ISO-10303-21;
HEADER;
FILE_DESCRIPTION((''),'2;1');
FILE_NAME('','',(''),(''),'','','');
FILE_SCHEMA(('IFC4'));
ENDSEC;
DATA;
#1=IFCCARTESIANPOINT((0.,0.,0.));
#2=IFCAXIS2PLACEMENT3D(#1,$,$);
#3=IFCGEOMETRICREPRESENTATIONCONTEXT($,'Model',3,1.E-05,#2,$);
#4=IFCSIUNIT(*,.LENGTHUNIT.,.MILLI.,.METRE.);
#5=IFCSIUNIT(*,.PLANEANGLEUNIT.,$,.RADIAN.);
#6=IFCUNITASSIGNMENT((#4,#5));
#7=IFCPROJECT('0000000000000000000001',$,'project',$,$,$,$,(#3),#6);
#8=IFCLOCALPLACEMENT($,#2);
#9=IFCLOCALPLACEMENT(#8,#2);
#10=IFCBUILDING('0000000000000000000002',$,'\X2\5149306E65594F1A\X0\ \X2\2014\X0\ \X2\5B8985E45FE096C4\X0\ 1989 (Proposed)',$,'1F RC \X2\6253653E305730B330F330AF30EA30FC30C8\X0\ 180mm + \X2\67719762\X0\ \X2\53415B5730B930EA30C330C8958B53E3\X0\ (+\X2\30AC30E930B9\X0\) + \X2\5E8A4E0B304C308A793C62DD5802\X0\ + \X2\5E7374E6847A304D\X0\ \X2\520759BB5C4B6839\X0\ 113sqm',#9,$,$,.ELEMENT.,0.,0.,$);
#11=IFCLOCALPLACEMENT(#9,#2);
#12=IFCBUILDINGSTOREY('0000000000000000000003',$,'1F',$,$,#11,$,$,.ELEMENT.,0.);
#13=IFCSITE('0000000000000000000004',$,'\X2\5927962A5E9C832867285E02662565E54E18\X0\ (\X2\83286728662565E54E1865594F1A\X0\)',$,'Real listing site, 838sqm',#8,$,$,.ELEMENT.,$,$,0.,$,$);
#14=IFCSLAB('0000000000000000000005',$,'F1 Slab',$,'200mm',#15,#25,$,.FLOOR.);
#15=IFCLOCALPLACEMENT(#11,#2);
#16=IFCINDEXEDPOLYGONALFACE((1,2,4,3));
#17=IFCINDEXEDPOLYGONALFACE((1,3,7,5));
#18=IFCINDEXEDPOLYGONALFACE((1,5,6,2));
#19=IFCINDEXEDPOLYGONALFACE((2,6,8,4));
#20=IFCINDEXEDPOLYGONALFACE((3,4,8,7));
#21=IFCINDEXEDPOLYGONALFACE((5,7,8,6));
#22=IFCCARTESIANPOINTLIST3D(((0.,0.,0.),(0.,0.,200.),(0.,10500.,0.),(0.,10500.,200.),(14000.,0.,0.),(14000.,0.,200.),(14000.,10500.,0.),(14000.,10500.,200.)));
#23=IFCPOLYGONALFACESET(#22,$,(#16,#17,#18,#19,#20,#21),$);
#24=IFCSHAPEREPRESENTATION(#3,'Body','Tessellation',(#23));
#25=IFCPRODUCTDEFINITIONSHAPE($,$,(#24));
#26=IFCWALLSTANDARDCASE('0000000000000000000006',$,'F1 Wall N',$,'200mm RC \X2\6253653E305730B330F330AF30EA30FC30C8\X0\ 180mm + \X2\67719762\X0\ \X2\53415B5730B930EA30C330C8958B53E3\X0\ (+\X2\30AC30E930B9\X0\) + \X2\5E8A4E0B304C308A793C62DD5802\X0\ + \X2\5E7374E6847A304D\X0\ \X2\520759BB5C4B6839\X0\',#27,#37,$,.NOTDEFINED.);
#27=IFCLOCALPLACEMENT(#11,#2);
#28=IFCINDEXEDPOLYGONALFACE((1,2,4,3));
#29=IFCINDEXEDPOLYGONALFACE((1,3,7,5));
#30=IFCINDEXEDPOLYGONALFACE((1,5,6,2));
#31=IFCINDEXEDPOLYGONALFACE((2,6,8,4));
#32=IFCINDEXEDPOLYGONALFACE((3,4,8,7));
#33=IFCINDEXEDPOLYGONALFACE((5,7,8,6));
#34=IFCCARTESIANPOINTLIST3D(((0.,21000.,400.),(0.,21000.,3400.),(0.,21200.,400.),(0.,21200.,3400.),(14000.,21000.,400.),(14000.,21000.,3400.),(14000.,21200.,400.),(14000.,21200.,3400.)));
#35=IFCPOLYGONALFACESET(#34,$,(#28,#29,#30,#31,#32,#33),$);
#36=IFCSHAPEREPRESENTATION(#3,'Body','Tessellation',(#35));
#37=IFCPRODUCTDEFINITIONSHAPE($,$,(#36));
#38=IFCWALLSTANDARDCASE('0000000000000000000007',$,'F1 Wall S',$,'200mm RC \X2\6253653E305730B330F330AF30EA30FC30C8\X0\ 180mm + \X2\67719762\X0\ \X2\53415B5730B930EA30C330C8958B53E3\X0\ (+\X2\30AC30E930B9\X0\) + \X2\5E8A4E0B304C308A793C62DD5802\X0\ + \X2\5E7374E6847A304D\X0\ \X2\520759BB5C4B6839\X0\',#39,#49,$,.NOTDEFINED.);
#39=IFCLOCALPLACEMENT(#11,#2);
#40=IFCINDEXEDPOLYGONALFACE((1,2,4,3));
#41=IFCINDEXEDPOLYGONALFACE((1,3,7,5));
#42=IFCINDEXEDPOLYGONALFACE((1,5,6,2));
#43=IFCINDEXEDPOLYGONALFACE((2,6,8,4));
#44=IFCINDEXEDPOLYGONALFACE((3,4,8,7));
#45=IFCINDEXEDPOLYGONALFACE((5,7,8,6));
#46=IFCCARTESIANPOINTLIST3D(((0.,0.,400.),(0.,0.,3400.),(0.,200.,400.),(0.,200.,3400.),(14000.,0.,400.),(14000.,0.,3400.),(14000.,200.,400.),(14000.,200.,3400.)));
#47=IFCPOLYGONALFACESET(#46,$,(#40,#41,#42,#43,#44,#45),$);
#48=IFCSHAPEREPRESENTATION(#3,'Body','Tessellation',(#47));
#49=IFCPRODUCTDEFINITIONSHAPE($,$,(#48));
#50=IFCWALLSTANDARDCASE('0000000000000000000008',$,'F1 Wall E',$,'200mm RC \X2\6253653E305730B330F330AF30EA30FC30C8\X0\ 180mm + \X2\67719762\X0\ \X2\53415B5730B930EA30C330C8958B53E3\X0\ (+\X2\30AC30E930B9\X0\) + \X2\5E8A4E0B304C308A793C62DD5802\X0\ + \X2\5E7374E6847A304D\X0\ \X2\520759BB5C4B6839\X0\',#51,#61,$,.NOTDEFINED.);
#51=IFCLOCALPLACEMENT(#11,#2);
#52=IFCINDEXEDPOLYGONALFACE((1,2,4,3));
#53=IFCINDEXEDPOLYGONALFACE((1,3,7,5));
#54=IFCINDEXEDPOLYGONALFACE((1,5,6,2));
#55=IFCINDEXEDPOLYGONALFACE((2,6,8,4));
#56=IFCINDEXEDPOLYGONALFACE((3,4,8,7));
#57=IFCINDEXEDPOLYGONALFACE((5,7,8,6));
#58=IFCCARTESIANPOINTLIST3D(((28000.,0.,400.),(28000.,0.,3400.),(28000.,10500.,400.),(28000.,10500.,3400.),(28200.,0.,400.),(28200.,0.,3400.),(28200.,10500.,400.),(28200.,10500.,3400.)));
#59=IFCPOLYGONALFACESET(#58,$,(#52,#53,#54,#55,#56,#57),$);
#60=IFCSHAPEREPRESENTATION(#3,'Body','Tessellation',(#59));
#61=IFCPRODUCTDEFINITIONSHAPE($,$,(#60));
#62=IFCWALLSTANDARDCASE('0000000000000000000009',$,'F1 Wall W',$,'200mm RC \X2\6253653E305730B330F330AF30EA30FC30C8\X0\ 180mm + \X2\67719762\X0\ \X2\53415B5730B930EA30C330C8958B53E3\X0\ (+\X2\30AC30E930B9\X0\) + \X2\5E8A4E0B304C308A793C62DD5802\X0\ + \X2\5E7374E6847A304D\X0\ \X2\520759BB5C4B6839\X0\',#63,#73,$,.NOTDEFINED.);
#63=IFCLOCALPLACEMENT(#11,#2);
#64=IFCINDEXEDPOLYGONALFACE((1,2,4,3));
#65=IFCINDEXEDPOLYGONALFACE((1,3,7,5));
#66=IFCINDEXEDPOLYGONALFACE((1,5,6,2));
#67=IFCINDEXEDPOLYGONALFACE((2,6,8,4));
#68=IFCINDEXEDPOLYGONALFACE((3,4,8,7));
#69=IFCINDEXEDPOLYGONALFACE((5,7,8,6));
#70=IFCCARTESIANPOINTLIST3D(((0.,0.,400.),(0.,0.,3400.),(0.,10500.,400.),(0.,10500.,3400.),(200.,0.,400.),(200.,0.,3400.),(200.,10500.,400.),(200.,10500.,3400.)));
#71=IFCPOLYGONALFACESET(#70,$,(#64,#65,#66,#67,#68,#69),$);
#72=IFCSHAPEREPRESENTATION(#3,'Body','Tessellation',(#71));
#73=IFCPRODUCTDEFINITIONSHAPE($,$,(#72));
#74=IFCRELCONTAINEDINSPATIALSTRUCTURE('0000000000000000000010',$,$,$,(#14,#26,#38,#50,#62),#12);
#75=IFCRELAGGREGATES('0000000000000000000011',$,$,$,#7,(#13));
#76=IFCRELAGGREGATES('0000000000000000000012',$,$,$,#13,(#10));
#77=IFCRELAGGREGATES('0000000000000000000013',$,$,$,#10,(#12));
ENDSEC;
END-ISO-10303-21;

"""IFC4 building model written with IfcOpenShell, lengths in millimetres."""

from ifc_helpers import new_model, si_unit, frame, frame_2d, origin, place, context, project, spatial, rectangle, extrude, element, save


model = new_model("IFC4")

# Units and contexts
model_context = context("Model", 3, precision=1e-05, world=origin())
ifc_project = project(units=[si_unit("LENGTHUNIT", "METRE", prefix="MILLI"), si_unit("PLANEANGLEUNIT", "RADIAN")], contexts=[model_context])

# Site, building, storey
site_placement = place(None, origin())
site = spatial("IfcSite", under=ifc_project, at=site_placement, Name="大阪府茨木市春日丘 (茨木春日丘教会)", ObjectType="Real listing site, 838sqm", CompositionType="ELEMENT", RefElevation=0.0)
building_placement = place(site_placement, origin())
building = spatial("IfcBuilding", under=site, at=building_placement, Name="光の教会 — 安藤忠雄 1989 (Proposed)", ObjectType="1F RC 打放しコンクリート 180mm + 東面 十字スリット開口 (+ガラス) + 床下がり礼拝堂 + 平瓦葺き 切妻屋根 113sqm", CompositionType="ELEMENT", ElevationOfRefHeight=0.0, ElevationOfTerrain=0.0)
storey_placement = place(building_placement, origin())
storey = spatial("IfcBuildingStorey", under=building, at=storey_placement, Name="1F", CompositionType="ELEMENT", Elevation=0.0)

# Slab
slab_placement = place(storey_placement, origin())
element("IfcSlab", 1, at=slab_placement, inside=storey, Name="F1 Slab", ObjectType="200mm", PredefinedType="FLOOR", context=model_context, shape_type="SweptSolid", body=[
    extrude(rectangle(XDim=14000.0, YDim=10500.0, at=frame_2d((7000.0, 5250.0))), origin(), (0.0, 0.0, 1.0), 200.0),
])

# Walls
wall_1_placement = place(storey_placement, frame((0.0, 10500.0, 200.0)))
element("IfcWallStandardCase", 2, at=wall_1_placement, inside=storey, Name="F1 Wall N", ObjectType="200mm RC 打放しコンクリート 180mm + 東面 十字スリット開口 (+ガラス) + 床下がり礼拝堂 + 平瓦葺き 切妻屋根", PredefinedType="NOTDEFINED", context=model_context, shape_type="SweptSolid", body=[
    extrude(rectangle(XDim=14000.0, YDim=200.0, at=frame_2d((7000.0, 100.0))), frame((0.0, 10500.0, 200.0)), (0.0, 0.0, 1.0), 3000.0),
])
wall_2_placement = place(storey_placement, frame((0.0, 0.0, 200.0)))
element("IfcWallStandardCase", 3, at=wall_2_placement, inside=storey, Name="F1 Wall S", ObjectType="200mm RC 打放しコンクリート 180mm + 東面 十字スリット開口 (+ガラス) + 床下がり礼拝堂 + 平瓦葺き 切妻屋根", PredefinedType="NOTDEFINED", context=model_context, shape_type="SweptSolid", body=[
    extrude(rectangle(XDim=14000.0, YDim=200.0, at=frame_2d((7000.0, 100.0))), frame((0.0, 0.0, 200.0)), (0.0, 0.0, 1.0), 3000.0),
])
wall_3_placement = place(storey_placement, frame((14000.0, 0.0, 200.0)))
element("IfcWallStandardCase", 4, at=wall_3_placement, inside=storey, Name="F1 Wall E", ObjectType="200mm RC 打放しコンクリート 180mm + 東面 十字スリット開口 (+ガラス) + 床下がり礼拝堂 + 平瓦葺き 切妻屋根", PredefinedType="NOTDEFINED", context=model_context, shape_type="SweptSolid", body=[
    extrude(rectangle(XDim=200.0, YDim=10500.0, at=frame_2d((100.0, 5250.0))), frame((14000.0, 0.0, 200.0)), (0.0, 0.0, 1.0), 3000.0),
])
wall_4_placement = place(storey_placement, frame((0.0, 0.0, 200.0)))
element("IfcWallStandardCase", 5, at=wall_4_placement, inside=storey, Name="F1 Wall W", ObjectType="200mm RC 打放しコンクリート 180mm + 東面 十字スリット開口 (+ガラス) + 床下がり礼拝堂 + 平瓦葺き 切妻屋根", PredefinedType="NOTDEFINED", context=model_context, shape_type="SweptSolid", body=[
    extrude(rectangle(XDim=200.0, YDim=10500.0, at=frame_2d((100.0, 5250.0))), frame((0.0, 0.0, 200.0)), (0.0, 0.0, 1.0), 3000.0),
])

save(model, "model.ifc")
